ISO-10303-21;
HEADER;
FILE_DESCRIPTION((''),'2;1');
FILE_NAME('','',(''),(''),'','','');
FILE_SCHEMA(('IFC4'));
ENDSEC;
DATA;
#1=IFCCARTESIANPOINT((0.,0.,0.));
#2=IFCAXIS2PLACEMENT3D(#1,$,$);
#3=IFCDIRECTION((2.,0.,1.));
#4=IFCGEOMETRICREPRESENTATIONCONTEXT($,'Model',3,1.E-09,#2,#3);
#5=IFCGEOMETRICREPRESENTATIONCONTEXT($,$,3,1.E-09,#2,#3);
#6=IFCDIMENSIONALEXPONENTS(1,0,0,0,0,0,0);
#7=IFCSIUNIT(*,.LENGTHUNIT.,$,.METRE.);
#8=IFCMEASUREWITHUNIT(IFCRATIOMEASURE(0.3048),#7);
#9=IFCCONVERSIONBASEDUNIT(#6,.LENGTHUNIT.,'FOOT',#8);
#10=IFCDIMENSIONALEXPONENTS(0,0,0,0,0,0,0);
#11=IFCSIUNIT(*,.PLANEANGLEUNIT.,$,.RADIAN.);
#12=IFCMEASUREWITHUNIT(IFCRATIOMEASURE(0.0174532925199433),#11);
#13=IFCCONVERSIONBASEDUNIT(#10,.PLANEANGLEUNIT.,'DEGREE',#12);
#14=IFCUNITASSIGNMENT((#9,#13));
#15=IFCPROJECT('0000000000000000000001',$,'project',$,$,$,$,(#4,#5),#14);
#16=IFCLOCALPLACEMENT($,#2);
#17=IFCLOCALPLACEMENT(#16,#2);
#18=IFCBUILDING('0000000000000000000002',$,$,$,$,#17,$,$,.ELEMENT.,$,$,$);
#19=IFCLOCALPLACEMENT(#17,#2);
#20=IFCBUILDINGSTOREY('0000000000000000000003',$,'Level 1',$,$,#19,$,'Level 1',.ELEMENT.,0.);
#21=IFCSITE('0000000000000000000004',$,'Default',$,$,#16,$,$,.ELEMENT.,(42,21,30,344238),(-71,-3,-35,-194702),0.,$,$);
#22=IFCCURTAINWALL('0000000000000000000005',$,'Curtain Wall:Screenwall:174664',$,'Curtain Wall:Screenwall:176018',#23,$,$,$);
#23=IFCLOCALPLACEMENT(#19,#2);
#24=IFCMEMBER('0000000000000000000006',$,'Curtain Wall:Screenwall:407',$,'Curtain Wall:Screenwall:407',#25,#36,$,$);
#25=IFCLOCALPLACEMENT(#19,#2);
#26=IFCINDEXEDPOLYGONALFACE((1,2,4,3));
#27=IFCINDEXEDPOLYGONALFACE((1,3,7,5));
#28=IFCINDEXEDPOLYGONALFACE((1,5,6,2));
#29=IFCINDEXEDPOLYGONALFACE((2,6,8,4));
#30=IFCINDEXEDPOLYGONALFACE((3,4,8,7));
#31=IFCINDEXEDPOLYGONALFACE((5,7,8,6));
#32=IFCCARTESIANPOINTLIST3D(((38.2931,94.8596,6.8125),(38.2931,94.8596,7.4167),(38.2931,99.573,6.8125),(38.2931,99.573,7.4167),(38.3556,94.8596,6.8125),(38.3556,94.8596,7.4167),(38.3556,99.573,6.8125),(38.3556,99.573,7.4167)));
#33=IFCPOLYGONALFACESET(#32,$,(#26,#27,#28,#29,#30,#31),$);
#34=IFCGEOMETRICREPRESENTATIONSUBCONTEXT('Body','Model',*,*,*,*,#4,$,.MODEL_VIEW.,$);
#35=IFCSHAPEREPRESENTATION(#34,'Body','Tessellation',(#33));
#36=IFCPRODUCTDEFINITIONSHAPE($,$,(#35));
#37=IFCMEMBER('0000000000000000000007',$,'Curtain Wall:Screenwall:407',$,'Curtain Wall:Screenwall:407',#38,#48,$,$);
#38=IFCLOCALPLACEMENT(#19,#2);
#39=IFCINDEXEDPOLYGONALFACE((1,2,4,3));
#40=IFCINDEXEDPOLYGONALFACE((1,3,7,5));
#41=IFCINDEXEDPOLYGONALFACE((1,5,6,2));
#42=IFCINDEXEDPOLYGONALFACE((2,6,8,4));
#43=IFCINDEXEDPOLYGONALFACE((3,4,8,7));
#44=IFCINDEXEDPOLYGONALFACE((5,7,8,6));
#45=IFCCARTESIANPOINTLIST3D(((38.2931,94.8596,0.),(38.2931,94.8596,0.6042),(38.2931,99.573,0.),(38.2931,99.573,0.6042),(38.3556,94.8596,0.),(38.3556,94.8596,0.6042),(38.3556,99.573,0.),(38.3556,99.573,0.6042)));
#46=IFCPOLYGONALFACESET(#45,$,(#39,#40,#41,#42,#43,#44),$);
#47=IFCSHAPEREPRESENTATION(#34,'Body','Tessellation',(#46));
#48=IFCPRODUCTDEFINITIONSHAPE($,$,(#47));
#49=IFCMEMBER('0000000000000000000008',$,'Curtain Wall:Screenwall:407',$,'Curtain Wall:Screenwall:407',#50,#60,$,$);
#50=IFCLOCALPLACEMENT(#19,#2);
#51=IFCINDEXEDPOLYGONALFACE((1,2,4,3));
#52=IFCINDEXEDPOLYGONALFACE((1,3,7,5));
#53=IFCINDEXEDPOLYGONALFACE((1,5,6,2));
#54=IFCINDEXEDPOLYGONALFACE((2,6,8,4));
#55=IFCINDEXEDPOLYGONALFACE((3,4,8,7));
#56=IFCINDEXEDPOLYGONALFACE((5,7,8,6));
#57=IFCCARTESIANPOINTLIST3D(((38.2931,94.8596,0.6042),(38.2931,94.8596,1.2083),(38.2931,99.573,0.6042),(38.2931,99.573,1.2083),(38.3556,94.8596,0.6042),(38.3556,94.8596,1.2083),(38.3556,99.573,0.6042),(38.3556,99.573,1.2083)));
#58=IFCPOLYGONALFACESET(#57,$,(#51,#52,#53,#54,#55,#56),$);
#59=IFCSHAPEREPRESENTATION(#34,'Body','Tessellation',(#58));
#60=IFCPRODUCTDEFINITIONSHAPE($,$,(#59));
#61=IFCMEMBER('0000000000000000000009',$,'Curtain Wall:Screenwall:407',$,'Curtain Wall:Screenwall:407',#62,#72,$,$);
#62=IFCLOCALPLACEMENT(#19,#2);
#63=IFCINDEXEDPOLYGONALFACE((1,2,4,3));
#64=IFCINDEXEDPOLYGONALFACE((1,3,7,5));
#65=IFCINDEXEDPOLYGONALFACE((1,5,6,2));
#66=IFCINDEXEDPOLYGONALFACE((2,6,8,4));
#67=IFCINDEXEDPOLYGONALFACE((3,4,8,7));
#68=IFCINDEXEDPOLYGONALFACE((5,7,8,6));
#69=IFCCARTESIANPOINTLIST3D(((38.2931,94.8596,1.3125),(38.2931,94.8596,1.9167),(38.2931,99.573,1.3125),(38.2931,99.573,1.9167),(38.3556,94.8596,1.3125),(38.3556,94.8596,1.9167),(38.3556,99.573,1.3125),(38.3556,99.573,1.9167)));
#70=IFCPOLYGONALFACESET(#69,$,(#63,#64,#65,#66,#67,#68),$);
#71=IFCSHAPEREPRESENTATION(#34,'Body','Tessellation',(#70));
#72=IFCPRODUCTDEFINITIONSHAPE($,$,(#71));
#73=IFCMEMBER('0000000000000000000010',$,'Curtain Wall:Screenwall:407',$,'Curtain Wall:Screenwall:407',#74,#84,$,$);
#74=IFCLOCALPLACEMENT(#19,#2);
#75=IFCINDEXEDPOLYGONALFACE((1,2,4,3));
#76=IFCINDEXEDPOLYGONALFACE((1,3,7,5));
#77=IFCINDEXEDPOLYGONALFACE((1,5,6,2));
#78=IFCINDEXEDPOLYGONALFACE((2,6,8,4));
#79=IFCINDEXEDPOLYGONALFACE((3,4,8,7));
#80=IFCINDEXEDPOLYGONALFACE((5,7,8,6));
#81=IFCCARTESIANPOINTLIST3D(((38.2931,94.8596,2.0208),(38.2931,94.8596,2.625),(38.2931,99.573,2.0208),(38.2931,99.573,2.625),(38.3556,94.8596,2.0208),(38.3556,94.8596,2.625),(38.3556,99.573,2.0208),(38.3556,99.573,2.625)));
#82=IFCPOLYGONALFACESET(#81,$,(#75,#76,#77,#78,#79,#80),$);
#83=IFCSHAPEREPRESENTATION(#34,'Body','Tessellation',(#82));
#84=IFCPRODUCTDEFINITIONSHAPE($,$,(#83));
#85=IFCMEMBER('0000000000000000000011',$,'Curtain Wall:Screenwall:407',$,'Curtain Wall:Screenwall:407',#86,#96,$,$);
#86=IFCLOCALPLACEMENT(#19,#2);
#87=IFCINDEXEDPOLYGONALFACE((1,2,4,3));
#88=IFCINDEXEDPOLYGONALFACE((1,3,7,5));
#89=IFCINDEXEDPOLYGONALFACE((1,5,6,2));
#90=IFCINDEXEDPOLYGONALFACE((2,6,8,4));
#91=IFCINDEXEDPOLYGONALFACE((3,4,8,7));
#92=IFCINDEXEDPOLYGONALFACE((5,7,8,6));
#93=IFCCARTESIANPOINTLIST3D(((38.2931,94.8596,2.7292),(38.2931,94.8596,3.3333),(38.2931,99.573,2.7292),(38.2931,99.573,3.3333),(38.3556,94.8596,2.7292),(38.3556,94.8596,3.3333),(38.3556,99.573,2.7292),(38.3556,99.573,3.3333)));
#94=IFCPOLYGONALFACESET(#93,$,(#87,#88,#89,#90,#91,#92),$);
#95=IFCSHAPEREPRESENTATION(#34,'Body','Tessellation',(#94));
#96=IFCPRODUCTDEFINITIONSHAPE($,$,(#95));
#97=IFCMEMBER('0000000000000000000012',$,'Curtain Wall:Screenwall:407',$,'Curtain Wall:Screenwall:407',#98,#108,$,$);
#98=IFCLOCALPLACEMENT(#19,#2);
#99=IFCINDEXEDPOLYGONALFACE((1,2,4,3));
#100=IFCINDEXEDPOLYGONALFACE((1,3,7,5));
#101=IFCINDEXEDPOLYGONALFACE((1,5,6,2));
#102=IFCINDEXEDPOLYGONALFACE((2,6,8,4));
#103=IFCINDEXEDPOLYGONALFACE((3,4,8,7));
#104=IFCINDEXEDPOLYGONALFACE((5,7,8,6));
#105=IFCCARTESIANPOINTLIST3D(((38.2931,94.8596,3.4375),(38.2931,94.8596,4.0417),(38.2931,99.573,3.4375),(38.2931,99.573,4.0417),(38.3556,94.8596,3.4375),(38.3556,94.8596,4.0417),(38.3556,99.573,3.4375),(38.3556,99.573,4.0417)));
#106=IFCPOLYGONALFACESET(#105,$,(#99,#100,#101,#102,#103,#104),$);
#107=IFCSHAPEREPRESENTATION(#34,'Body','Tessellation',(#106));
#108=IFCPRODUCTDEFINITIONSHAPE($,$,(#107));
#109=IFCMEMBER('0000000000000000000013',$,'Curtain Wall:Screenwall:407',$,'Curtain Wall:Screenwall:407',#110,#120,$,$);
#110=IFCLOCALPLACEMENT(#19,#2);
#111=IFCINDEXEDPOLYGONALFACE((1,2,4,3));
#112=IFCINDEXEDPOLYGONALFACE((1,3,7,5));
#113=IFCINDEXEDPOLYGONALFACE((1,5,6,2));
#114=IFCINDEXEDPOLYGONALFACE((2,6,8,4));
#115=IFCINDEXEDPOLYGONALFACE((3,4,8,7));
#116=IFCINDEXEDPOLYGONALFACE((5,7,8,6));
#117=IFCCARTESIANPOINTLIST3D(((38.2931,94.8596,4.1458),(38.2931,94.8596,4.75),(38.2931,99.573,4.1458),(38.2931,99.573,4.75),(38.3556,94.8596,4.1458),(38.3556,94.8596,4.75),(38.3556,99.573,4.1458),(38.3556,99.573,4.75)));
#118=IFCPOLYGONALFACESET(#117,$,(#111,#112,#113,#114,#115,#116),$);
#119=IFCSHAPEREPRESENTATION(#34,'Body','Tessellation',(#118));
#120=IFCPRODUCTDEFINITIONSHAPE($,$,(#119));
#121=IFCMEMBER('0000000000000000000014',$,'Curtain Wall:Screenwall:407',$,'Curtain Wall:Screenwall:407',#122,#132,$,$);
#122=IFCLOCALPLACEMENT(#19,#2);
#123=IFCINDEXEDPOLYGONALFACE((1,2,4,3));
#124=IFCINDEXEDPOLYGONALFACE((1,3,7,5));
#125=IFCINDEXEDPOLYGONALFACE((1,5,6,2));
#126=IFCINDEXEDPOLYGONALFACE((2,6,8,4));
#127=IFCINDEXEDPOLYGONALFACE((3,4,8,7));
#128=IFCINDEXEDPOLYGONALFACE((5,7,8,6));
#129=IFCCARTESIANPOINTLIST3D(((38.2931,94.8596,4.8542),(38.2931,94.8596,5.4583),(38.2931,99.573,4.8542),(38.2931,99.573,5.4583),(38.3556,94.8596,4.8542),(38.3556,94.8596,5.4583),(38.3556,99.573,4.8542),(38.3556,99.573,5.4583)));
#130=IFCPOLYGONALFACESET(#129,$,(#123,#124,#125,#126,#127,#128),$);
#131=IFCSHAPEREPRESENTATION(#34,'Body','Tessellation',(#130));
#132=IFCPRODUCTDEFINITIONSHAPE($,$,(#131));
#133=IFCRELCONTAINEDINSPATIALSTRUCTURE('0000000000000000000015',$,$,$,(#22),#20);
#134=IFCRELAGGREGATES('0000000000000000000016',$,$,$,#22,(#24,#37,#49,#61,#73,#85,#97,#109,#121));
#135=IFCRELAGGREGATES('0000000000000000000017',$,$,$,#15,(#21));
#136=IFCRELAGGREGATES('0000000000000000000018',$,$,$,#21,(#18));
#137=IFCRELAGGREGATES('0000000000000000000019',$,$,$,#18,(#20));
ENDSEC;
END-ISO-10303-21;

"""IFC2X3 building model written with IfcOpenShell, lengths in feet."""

from ifc_helpers import new_model, entity, si_unit, converted_unit, direction, frame, frame_2d, origin, origin_2d_with_axis, place, context, subcontext, project, spatial, rectangle, extrude, element, aggregate, save


model = new_model("IFC2X3")

# Units and contexts
model_context = context("Model", 3, precision=1e-09, world=origin(), true_north=direction((2.0, 0.0, 1.0)))
context_of_model = context(None, 3, precision=1e-09, world=origin(), true_north=direction((2.0, 0.0, 1.0)))
body_context = subcontext(model_context, "Body", "Model", "MODEL_VIEW")
ifc_project = project(units=[converted_unit("LENGTHUNIT", "FOOT", entity("IfcRatioMeasure", 0.3048), si_unit("LENGTHUNIT", "METRE"), dimensions=[1, 0, 0, 0, 0, 0, 0]), converted_unit("PLANEANGLEUNIT", "DEGREE", entity("IfcRatioMeasure", 0.0174532925199433), si_unit("PLANEANGLEUNIT", "RADIAN"), dimensions=[0, 0, 0, 0, 0, 0, 0])], contexts=[model_context, context_of_model])

# Site, building, storey
site_placement = place(None, origin())
site = spatial("IfcSite", under=ifc_project, at=site_placement, Name="Default", CompositionType="ELEMENT", RefLatitude=(42, 21, 30, 344238), RefLongitude=(-71, -3, -35, -194702), RefElevation=0.0)
building_placement = place(site_placement, origin())
building = spatial("IfcBuilding", under=site, at=building_placement, CompositionType="ELEMENT")
storey_placement = place(building_placement, origin())
storey = spatial("IfcBuildingStorey", under=building, at=storey_placement, Name="Level 1", LongName="Level 1", CompositionType="ELEMENT", Elevation=0.0)

# Curtain wall, members
curtain_wall_1_placement = place(storey_placement, origin())
curtain_wall_1 = element("IfcCurtainWall", 1, at=curtain_wall_1_placement, inside=storey, Name="Curtain Wall:Screenwall:174664", ObjectType="Curtain Wall:Screenwall:176018")
member_1_placement = place(curtain_wall_1_placement, frame((38.2931, 94.8596, 6.8125)))
member_1 = element("IfcMember", 2, at=member_1_placement, Name="Curtain Wall:Screenwall:407", ObjectType="Curtain Wall:Screenwall:407", context=body_context, shape_type="SweptSolid", body=[
    extrude(rectangle(XDim=4.7134, YDim=0.0625, at=origin_2d_with_axis()), frame((0.0312, 2.3567, 0.0), z_axis=(0.0, 0.0, 1.0), x_axis=(0.0, 1.0, 0.0)), (0.0, 0.0, 1.0), 0.6042),
])
member_2_placement = place(curtain_wall_1_placement, frame((38.2931, 94.8596, 0.0)))
member_2 = element("IfcMember", 3, at=member_2_placement, Name="Curtain Wall:Screenwall:407", ObjectType="Curtain Wall:Screenwall:407", context=body_context, shape_type="SweptSolid", body=[
    extrude(rectangle(XDim=4.7134, YDim=0.0625, at=frame_2d((0.0, 0.0), x_axis=(1.0, 0.0))), frame((0.0312, 2.3567, 0.0), z_axis=(0.0, 0.0, 1.0), x_axis=(0.0, -1.0, 0.0)), (0.0, 0.0, 1.0), 0.6042),
])
member_3_placement = place(curtain_wall_1_placement, frame((38.2931, 94.8596, 0.6042)))
member_3 = element("IfcMember", 4, at=member_3_placement, Name="Curtain Wall:Screenwall:407", ObjectType="Curtain Wall:Screenwall:407", context=body_context, shape_type="SweptSolid", body=[
    extrude(rectangle(XDim=4.7134, YDim=0.0625, at=origin_2d_with_axis()), frame((0.0312, 2.3567, 0.0), z_axis=(0.0, 0.0, 1.0), x_axis=(0.0, 1.0, 0.0)), (0.0, 0.0, 1.0), 0.6042),
])
member_4_placement = place(curtain_wall_1_placement, frame((38.2931, 94.8596, 1.3125)))
member_4 = element("IfcMember", 5, at=member_4_placement, Name="Curtain Wall:Screenwall:407", ObjectType="Curtain Wall:Screenwall:407", context=body_context, shape_type="SweptSolid", body=[
    extrude(rectangle(XDim=4.7134, YDim=0.0625, at=origin_2d_with_axis()), frame((0.0312, 2.3567, 0.0), z_axis=(0.0, 0.0, 1.0), x_axis=(0.0, 1.0, 0.0)), (0.0, 0.0, 1.0), 0.6042),
])
member_5_placement = place(curtain_wall_1_placement, frame((38.2931, 94.8596, 2.0208)))
member_5 = element("IfcMember", 6, at=member_5_placement, Name="Curtain Wall:Screenwall:407", ObjectType="Curtain Wall:Screenwall:407", context=body_context, shape_type="SweptSolid", body=[
    extrude(rectangle(XDim=4.7134, YDim=0.0625, at=origin_2d_with_axis()), frame((0.0312, 2.3567, 0.0), z_axis=(0.0, 0.0, 1.0), x_axis=(0.0, 1.0, 0.0)), (0.0, 0.0, 1.0), 0.6042),
])
member_6_placement = place(curtain_wall_1_placement, frame((38.2931, 94.8596, 2.7292)))
member_6 = element("IfcMember", 7, at=member_6_placement, Name="Curtain Wall:Screenwall:407", ObjectType="Curtain Wall:Screenwall:407", context=body_context, shape_type="SweptSolid", body=[
    extrude(rectangle(XDim=4.7134, YDim=0.0625, at=origin_2d_with_axis()), frame((0.0312, 2.3567, 0.0), z_axis=(0.0, 0.0, 1.0), x_axis=(0.0, 1.0, 0.0)), (0.0, 0.0, 1.0), 0.6042),
])
member_7_placement = place(curtain_wall_1_placement, frame((38.2931, 94.8596, 3.4375)))
member_7 = element("IfcMember", 8, at=member_7_placement, Name="Curtain Wall:Screenwall:407", ObjectType="Curtain Wall:Screenwall:407", context=body_context, shape_type="SweptSolid", body=[
    extrude(rectangle(XDim=4.7134, YDim=0.0625, at=origin_2d_with_axis()), frame((0.0312, 2.3567, 0.0), z_axis=(0.0, 0.0, 1.0), x_axis=(0.0, 1.0, 0.0)), (0.0, 0.0, 1.0), 0.6042),
])
member_8_placement = place(curtain_wall_1_placement, frame((38.2931, 94.8596, 4.1458)))
member_8 = element("IfcMember", 9, at=member_8_placement, Name="Curtain Wall:Screenwall:407", ObjectType="Curtain Wall:Screenwall:407", context=body_context, shape_type="SweptSolid", body=[
    extrude(rectangle(XDim=4.7134, YDim=0.0625, at=origin_2d_with_axis()), frame((0.0312, 2.3567, 0.0), z_axis=(0.0, 0.0, 1.0), x_axis=(0.0, 1.0, 0.0)), (0.0, 0.0, 1.0), 0.6042),
])
member_9_placement = place(curtain_wall_1_placement, frame((38.2931, 94.8596, 4.8542)))
member_9 = element("IfcMember", 10, at=member_9_placement, Name="Curtain Wall:Screenwall:407", ObjectType="Curtain Wall:Screenwall:407", context=body_context, shape_type="SweptSolid", body=[
    extrude(rectangle(XDim=4.7134, YDim=0.0625, at=origin_2d_with_axis()), frame((0.0312, 2.3567, 0.0), z_axis=(0.0, 0.0, 1.0), x_axis=(0.0, 1.0, 0.0)), (0.0, 0.0, 1.0), 0.6042),
])
aggregate(curtain_wall_1, [member_1, member_2, member_3, member_4, member_5, member_6, member_7, member_8, member_9])

save(model, "model.ifc")
